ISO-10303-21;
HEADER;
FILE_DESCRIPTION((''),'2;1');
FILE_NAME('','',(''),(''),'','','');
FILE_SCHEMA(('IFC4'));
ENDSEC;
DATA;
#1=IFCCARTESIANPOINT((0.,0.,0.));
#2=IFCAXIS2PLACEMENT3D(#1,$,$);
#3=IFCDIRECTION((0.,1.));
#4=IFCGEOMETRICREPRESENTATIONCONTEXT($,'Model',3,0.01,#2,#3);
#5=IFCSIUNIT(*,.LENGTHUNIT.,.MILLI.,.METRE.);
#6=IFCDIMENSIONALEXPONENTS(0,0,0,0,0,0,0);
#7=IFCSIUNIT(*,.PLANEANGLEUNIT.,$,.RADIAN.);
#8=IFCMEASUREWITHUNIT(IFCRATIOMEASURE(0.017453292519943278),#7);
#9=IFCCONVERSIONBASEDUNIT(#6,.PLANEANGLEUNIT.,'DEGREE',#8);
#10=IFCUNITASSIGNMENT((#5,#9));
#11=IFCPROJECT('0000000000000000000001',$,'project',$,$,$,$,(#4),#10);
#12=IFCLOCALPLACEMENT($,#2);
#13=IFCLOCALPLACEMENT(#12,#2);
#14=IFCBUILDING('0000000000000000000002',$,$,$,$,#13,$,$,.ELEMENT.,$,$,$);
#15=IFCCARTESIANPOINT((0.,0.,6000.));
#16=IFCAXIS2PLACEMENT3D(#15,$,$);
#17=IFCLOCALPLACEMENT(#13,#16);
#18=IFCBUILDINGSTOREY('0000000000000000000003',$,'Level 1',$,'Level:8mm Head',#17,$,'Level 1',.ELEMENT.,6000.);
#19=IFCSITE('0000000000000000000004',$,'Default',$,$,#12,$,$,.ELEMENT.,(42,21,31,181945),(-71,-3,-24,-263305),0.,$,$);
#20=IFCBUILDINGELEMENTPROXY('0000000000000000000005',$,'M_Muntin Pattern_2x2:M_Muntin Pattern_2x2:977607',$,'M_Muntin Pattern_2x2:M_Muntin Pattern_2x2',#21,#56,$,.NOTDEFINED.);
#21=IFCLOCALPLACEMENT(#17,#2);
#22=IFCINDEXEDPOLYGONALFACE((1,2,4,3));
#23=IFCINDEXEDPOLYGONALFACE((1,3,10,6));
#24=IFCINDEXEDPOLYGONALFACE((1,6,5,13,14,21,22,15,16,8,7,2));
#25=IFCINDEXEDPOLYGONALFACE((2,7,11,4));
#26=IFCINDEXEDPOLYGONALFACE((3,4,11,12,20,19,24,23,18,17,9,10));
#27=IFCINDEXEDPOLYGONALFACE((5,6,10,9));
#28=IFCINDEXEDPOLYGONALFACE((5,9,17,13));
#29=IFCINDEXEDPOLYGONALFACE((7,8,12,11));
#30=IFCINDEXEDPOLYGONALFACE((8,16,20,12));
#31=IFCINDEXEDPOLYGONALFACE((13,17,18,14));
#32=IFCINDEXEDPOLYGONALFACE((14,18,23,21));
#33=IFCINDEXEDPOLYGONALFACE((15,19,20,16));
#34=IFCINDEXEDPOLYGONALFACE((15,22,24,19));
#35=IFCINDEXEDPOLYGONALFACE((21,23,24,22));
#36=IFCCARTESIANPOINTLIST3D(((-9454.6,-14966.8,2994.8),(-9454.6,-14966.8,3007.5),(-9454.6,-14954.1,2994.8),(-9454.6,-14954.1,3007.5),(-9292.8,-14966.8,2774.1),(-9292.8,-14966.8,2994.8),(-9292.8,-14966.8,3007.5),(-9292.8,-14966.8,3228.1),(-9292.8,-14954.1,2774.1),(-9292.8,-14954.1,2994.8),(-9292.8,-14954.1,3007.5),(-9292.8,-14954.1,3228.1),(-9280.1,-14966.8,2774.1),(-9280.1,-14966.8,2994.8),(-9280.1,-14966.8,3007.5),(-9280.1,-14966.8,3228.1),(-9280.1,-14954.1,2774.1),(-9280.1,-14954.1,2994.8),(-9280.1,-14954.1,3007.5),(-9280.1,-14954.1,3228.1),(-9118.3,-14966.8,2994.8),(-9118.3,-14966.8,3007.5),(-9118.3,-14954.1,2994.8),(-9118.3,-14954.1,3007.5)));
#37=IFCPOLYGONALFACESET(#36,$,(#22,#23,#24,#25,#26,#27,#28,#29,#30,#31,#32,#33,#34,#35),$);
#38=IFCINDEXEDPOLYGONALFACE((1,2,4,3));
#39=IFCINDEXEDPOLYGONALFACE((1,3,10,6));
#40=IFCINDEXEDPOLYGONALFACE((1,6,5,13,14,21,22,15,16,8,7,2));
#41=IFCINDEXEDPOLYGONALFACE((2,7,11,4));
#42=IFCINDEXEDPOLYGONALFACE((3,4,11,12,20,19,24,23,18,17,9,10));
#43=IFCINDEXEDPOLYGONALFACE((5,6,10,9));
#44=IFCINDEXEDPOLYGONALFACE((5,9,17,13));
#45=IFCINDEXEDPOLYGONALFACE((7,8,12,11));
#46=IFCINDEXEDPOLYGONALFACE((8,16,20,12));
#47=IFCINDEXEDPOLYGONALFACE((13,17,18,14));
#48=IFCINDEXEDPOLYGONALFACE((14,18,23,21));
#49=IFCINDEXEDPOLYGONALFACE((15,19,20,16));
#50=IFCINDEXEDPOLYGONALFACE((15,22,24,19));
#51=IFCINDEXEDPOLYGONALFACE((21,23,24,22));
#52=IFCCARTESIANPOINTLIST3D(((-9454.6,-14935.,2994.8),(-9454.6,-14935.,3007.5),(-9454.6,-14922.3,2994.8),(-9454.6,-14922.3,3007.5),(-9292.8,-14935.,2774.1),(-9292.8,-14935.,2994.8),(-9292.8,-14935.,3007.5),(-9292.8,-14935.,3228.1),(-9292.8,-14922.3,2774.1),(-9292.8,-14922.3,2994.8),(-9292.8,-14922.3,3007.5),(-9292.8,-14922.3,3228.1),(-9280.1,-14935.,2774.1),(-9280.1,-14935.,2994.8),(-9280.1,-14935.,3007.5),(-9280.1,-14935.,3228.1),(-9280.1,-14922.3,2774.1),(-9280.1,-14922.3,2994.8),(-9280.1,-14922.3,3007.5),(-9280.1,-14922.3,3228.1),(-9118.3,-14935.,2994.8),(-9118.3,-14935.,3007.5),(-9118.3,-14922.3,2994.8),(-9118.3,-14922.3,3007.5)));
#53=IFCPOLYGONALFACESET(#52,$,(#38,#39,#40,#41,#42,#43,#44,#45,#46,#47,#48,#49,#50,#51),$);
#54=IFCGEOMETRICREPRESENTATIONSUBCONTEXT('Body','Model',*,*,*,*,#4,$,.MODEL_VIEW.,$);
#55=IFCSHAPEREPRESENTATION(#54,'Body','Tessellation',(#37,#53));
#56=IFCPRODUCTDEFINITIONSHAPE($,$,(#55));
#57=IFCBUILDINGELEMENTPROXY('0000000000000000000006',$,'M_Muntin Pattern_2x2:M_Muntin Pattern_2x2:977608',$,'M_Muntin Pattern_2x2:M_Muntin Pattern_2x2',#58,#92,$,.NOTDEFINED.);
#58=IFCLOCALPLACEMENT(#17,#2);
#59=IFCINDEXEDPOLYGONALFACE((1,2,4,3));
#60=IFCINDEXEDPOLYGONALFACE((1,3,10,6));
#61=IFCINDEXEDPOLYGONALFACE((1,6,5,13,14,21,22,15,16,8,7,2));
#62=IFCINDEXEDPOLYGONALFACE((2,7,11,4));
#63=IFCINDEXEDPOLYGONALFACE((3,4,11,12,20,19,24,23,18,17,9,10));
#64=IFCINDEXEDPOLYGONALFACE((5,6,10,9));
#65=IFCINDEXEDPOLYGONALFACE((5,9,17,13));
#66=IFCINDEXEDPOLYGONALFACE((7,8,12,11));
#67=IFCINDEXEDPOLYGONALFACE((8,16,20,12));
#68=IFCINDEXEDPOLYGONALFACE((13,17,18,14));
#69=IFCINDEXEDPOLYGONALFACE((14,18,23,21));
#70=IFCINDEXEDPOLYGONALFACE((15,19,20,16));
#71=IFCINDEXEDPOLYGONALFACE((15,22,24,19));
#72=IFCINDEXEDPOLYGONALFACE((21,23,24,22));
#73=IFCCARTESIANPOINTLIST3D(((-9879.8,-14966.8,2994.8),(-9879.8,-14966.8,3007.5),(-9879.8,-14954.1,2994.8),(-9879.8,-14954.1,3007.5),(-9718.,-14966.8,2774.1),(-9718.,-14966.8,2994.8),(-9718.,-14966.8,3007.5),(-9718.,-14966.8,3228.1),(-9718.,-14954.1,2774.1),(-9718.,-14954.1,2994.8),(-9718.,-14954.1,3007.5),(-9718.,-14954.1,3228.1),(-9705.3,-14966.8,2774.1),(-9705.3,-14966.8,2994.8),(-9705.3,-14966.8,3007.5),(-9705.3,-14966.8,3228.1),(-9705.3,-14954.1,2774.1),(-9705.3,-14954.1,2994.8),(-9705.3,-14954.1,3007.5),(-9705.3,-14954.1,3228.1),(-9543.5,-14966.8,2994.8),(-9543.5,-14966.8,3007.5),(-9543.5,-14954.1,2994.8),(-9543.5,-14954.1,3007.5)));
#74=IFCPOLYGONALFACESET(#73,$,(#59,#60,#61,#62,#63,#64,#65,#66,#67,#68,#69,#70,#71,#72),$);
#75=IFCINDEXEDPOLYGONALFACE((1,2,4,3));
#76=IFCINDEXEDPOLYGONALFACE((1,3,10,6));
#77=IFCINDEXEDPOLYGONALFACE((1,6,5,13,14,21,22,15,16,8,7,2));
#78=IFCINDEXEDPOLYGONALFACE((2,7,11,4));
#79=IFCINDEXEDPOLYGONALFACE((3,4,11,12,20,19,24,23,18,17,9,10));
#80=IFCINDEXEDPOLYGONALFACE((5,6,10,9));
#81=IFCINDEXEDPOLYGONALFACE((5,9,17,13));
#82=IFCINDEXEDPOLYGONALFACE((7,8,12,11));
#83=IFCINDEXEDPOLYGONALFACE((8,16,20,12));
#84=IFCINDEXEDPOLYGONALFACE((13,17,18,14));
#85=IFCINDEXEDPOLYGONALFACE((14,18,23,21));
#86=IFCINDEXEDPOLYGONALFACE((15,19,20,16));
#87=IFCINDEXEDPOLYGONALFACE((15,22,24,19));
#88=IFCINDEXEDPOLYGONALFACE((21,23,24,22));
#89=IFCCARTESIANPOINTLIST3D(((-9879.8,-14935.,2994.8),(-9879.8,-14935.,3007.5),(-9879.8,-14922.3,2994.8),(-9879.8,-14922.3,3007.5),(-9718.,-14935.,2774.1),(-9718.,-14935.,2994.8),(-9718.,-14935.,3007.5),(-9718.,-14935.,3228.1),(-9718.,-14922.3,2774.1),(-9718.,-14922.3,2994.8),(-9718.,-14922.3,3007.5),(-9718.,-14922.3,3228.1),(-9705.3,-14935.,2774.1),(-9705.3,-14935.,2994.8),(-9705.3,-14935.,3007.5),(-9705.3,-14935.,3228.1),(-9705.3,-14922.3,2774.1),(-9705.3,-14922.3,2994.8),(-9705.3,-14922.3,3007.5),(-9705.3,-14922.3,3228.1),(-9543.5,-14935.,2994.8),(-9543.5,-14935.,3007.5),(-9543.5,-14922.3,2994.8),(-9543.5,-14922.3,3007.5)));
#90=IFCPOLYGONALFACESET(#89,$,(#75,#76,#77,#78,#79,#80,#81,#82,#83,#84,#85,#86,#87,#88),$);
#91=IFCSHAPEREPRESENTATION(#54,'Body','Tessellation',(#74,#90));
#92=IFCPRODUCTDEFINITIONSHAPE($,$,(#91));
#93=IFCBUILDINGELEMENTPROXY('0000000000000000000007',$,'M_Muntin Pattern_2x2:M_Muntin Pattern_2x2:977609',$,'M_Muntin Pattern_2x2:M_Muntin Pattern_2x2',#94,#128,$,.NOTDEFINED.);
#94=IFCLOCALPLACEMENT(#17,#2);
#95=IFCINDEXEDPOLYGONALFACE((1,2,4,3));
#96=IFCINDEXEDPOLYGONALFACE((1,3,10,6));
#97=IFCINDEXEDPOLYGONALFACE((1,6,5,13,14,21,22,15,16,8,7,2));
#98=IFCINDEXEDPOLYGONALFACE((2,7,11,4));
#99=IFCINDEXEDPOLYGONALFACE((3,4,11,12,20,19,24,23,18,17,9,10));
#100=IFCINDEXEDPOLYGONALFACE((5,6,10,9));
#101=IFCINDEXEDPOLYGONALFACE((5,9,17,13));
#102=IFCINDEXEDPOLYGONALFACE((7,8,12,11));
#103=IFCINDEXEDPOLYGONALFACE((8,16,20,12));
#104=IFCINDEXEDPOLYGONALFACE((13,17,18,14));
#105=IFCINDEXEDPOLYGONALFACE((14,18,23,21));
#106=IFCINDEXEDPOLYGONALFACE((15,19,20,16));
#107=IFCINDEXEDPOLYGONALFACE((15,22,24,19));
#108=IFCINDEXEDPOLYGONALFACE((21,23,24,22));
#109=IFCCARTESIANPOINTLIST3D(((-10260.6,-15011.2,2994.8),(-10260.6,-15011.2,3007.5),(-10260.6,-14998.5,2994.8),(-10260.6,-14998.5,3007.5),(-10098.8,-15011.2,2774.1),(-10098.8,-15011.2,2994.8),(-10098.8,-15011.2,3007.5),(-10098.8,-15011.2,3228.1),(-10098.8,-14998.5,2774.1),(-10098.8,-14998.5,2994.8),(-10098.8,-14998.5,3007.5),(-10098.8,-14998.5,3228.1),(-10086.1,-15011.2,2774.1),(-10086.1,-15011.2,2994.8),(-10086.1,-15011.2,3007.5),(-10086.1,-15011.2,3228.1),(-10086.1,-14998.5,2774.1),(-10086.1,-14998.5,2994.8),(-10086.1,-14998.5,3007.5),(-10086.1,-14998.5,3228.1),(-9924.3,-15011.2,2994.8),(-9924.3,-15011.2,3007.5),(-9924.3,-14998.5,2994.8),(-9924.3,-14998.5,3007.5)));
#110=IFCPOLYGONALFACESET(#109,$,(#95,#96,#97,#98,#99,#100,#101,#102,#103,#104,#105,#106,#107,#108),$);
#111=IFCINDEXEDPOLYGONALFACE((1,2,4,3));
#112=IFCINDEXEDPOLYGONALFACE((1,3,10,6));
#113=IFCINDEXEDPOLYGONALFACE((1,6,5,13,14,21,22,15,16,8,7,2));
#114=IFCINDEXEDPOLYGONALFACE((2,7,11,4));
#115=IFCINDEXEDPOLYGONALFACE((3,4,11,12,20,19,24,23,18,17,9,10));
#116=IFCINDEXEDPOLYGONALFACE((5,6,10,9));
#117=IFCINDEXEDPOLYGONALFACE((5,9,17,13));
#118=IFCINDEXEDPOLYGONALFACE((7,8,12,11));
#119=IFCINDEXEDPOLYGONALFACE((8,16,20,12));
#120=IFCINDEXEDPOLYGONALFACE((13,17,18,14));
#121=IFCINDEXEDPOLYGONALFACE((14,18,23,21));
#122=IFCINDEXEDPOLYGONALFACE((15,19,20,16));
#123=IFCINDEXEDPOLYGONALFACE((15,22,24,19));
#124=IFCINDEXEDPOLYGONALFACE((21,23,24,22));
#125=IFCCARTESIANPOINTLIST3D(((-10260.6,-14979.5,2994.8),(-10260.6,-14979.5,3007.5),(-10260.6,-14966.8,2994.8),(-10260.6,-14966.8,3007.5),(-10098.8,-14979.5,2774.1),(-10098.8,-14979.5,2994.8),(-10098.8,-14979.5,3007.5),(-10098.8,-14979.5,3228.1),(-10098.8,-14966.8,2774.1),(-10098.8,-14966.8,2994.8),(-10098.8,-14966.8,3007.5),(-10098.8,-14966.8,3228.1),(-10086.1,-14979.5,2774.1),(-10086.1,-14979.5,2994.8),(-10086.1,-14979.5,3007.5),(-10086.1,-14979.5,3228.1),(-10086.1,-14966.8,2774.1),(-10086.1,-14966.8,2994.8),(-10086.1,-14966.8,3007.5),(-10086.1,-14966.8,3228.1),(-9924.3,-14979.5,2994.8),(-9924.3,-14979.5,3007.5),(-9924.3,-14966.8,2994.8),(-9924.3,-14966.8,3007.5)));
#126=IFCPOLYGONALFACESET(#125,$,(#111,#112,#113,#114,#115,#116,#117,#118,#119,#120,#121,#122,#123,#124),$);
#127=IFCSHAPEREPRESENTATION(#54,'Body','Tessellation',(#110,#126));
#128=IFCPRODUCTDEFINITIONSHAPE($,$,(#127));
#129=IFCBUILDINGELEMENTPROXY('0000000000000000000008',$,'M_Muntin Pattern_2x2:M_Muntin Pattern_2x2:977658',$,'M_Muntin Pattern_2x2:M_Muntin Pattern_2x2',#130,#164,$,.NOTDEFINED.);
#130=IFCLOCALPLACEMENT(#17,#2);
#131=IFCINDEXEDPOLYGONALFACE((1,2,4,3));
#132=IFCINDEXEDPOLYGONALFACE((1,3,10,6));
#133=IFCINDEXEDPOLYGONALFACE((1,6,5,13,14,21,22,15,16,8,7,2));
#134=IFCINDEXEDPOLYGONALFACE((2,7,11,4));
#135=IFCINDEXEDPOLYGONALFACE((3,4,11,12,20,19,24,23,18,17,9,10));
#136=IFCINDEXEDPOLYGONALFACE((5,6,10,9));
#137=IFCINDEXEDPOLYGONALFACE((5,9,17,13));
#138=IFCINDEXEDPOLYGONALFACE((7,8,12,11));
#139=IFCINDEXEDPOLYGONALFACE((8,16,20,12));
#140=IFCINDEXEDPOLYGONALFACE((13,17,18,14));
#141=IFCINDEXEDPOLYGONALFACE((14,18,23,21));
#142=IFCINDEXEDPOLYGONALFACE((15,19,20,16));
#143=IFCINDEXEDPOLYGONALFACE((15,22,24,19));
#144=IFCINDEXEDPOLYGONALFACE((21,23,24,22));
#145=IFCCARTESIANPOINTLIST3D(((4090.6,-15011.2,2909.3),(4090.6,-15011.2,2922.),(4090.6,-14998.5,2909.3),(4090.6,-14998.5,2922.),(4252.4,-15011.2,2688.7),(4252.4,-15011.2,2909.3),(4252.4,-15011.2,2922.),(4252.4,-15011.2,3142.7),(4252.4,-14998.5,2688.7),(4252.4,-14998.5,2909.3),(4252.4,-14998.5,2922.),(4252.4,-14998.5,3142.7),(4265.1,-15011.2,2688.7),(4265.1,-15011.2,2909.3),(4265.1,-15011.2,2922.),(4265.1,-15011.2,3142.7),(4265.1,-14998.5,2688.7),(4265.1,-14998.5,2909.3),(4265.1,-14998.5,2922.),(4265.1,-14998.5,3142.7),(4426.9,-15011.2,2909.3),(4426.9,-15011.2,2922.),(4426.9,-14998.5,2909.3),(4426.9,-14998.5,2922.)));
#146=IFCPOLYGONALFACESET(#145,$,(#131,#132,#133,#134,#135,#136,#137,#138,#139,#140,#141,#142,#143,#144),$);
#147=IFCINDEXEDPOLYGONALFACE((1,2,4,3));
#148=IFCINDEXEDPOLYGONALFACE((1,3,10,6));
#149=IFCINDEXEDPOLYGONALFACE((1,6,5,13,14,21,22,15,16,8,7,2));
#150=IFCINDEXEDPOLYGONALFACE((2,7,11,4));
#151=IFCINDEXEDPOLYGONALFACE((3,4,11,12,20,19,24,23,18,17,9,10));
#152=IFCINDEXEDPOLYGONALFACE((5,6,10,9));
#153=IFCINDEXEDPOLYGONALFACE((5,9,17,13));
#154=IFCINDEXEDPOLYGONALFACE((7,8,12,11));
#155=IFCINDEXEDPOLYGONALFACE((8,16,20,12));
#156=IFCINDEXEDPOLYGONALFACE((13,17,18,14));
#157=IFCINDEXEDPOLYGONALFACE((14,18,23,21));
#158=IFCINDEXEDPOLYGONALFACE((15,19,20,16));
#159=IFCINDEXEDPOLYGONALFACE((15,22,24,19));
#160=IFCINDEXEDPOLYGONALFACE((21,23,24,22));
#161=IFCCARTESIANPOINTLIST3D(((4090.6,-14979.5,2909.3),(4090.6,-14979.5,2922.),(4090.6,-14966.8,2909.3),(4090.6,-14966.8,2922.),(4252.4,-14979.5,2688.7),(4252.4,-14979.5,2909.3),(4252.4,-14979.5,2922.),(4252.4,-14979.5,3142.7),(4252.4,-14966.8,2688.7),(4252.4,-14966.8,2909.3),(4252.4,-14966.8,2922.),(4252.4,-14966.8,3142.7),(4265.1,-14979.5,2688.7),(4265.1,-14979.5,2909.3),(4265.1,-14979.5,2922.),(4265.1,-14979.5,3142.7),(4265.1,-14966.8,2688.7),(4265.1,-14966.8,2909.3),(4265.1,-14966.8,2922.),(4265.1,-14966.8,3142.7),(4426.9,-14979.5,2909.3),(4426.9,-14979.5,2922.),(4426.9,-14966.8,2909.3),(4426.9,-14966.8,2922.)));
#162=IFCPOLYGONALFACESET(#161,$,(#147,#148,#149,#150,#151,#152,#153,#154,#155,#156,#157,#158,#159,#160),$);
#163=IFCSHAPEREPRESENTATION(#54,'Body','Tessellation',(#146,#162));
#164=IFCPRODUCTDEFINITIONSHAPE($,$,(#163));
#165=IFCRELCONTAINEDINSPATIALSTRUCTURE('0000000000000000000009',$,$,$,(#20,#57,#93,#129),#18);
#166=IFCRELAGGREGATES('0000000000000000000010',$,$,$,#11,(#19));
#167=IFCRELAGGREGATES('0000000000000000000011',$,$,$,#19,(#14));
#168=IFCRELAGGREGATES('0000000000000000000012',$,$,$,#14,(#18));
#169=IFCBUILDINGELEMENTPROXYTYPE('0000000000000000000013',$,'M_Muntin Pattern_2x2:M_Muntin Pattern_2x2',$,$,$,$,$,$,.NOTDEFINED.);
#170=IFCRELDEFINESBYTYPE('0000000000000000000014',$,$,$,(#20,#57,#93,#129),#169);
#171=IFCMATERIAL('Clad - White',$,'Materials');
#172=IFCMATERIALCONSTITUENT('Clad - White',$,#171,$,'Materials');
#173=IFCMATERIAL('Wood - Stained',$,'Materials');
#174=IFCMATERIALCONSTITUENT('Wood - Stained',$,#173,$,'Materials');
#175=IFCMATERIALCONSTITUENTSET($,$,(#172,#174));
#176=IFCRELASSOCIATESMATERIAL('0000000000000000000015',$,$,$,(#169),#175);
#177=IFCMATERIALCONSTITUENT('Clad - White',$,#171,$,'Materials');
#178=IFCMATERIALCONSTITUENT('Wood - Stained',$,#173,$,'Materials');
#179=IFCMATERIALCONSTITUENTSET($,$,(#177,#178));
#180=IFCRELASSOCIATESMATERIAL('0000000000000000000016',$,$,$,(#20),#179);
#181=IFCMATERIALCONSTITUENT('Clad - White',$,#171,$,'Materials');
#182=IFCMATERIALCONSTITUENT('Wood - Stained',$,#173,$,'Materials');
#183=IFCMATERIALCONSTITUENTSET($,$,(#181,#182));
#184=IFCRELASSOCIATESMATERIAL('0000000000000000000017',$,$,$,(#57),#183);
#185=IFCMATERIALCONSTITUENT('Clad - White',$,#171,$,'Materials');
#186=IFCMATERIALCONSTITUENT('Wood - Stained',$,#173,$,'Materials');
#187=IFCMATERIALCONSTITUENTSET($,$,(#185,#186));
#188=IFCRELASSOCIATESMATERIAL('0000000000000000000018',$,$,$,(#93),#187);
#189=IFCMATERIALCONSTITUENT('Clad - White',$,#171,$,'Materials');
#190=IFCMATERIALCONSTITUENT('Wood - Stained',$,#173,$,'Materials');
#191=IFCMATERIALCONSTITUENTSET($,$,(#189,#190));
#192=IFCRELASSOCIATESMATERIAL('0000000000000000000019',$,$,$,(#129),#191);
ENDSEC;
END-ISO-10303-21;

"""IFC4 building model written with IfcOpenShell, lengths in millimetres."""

from ifc_helpers import new_model, entity, si_unit, converted_unit, direction, frame, origin, place, context, subcontext, project, spatial, polyline, outline, extrude, source, transform, mapped, material, constituent, constituent_set, type_object, type_shapes, element, save


model = new_model("IFC4")

# Units and contexts
model_context = context("Model", 3, precision=0.01, world=origin(), true_north=direction((0.0, 1.0)))
body_context = subcontext(model_context, "Body", "Model", "MODEL_VIEW")
ifc_project = project(units=[si_unit("LENGTHUNIT", "METRE", prefix="MILLI"), converted_unit("PLANEANGLEUNIT", "DEGREE", entity("IfcRatioMeasure", 0.017453292519943278), si_unit("PLANEANGLEUNIT", "RADIAN"), dimensions=[0, 0, 0, 0, 0, 0, 0])], contexts=[model_context])

# Site, building, storey
site_placement = place(None, origin())
site = spatial("IfcSite", under=ifc_project, at=site_placement, Name="Default", CompositionType="ELEMENT", RefLatitude=(42, 21, 31, 181945), RefLongitude=(-71, -3, -24, -263305), RefElevation=0.0)
building_placement = place(site_placement, origin())
building = spatial("IfcBuilding", under=site, at=building_placement, CompositionType="ELEMENT")
storey_placement = place(building_placement, frame((0.0, 0.0, 6000.0)))
storey = spatial("IfcBuildingStorey", under=building, at=storey_placement, Name="Level 1", ObjectType="Level:8mm Head", LongName="Level 1", CompositionType="ELEMENT", Elevation=6000.0)

# Building element proxies
ifc_material_1 = material(Name="Clad - White", Category="Materials")
ifc_material_2 = material(Name="Wood - Stained", Category="Materials")
ifc_constituent_1 = constituent(ifc_material_1, Name="Clad - White", Category="Materials")
ifc_constituent_2 = constituent(ifc_material_2, Name="Wood - Stained", Category="Materials")
ifc_constituent_set_1 = constituent_set(constituents=[ifc_constituent_1, ifc_constituent_2])
building_element_proxy_type_1 = type_object("IfcBuildingElementProxyType", Name="M_Muntin Pattern_2x2:M_Muntin Pattern_2x2", PredefinedType="NOTDEFINED", material=ifc_constituent_set_1)
shared_shape_1 = source(origin(), body_context, "Body", "SweptSolid", [
    extrude(outline(polyline([(6.4, -6.4), (227.0, -6.4), (227.0, 6.3), (6.4, 6.3), (6.4, 168.2), (-6.3, 168.2), (-6.3, 6.3), (-227.0, 6.3), (-227.0, -6.4), (-6.3, -6.4), (-6.3, -168.1), (6.4, -168.1), (6.4, -6.4)])), frame((0.0, 9.5, 227.0), z_axis=(0.0, 1.0, 0.0), x_axis=(0.0, 0.0, 1.0)), (0.0, 0.0, 1.0), 12.7),
    extrude(outline(polyline([(6.4, -6.4), (227.0, -6.4), (227.0, 6.3), (6.4, 6.3), (6.4, 168.2), (-6.3, 168.2), (-6.3, 6.3), (-227.0, 6.3), (-227.0, -6.4), (-6.3, -6.4), (-6.3, -168.1), (6.4, -168.1), (6.4, -6.4)])), frame((0.0, -22.2, 227.0), z_axis=(0.0, 1.0, 0.0), x_axis=(0.0, 0.0, 1.0)), (0.0, 0.0, 1.0), 12.7),
])
type_shapes(building_element_proxy_type_1, [shared_shape_1])
ifc_constituent_3 = constituent(ifc_material_1, Name="Clad - White", Category="Materials")
ifc_constituent_4 = constituent(ifc_material_2, Name="Wood - Stained", Category="Materials")
ifc_constituent_set_2 = constituent_set(constituents=[ifc_constituent_3, ifc_constituent_4])
proxy_1_placement = place(storey_placement, frame((-9286.5, -14944.6, 2774.1), z_axis=(0.0, 0.0, 1.0), x_axis=(-1.0, 0.0, 0.0)))
element("IfcBuildingElementProxy", 1, at=proxy_1_placement, inside=storey, type_object=building_element_proxy_type_1, material=ifc_constituent_set_2, Name="M_Muntin Pattern_2x2:M_Muntin Pattern_2x2:977607", ObjectType="M_Muntin Pattern_2x2:M_Muntin Pattern_2x2", PredefinedType="NOTDEFINED", context=body_context, shape_type="MappedRepresentation", body=[
    mapped(shared_shape_1, transform((0.0, 0.0, 0.0), scale=1.0)),
])
ifc_constituent_5 = constituent(ifc_material_1, Name="Clad - White", Category="Materials")
ifc_constituent_6 = constituent(ifc_material_2, Name="Wood - Stained", Category="Materials")
ifc_constituent_set_3 = constituent_set(constituents=[ifc_constituent_5, ifc_constituent_6])
proxy_2_placement = place(storey_placement, frame((-9711.7, -14944.6, 2774.1), z_axis=(0.0, 0.0, 1.0), x_axis=(-1.0, 0.0, 0.0)))
element("IfcBuildingElementProxy", 2, at=proxy_2_placement, inside=storey, type_object=building_element_proxy_type_1, material=ifc_constituent_set_3, Name="M_Muntin Pattern_2x2:M_Muntin Pattern_2x2:977608", ObjectType="M_Muntin Pattern_2x2:M_Muntin Pattern_2x2", PredefinedType="NOTDEFINED", context=body_context, shape_type="MappedRepresentation", body=[
    mapped(shared_shape_1, transform((0.0, 0.0, 0.0), scale=1.0)),
])
ifc_constituent_7 = constituent(ifc_material_1, Name="Clad - White", Category="Materials")
ifc_constituent_8 = constituent(ifc_material_2, Name="Wood - Stained", Category="Materials")
ifc_constituent_set_4 = constituent_set(constituents=[ifc_constituent_7, ifc_constituent_8])
proxy_3_placement = place(storey_placement, frame((-10092.4, -14989.0, 2774.1), z_axis=(0.0, 0.0, 1.0), x_axis=(-1.0, 0.0, 0.0)))
element("IfcBuildingElementProxy", 3, at=proxy_3_placement, inside=storey, type_object=building_element_proxy_type_1, material=ifc_constituent_set_4, Name="M_Muntin Pattern_2x2:M_Muntin Pattern_2x2:977609", ObjectType="M_Muntin Pattern_2x2:M_Muntin Pattern_2x2", PredefinedType="NOTDEFINED", context=body_context, shape_type="MappedRepresentation", body=[
    mapped(shared_shape_1, transform((0.0, 0.0, 0.0), scale=1.0)),
])
ifc_constituent_9 = constituent(ifc_material_1, Name="Clad - White", Category="Materials")
ifc_constituent_10 = constituent(ifc_material_2, Name="Wood - Stained", Category="Materials")
ifc_constituent_set_5 = constituent_set(constituents=[ifc_constituent_9, ifc_constituent_10])
proxy_4_placement = place(storey_placement, frame((4258.8, -14989.0, 2688.7), z_axis=(0.0, 0.0, 1.0), x_axis=(-1.0, 0.0, 0.0)))
element("IfcBuildingElementProxy", 4, at=proxy_4_placement, inside=storey, type_object=building_element_proxy_type_1, material=ifc_constituent_set_5, Name="M_Muntin Pattern_2x2:M_Muntin Pattern_2x2:977658", ObjectType="M_Muntin Pattern_2x2:M_Muntin Pattern_2x2", PredefinedType="NOTDEFINED", context=body_context, shape_type="MappedRepresentation", body=[
    mapped(shared_shape_1, transform((0.0, 0.0, 0.0), scale=1.0)),
])

save(model, "model.ifc")
